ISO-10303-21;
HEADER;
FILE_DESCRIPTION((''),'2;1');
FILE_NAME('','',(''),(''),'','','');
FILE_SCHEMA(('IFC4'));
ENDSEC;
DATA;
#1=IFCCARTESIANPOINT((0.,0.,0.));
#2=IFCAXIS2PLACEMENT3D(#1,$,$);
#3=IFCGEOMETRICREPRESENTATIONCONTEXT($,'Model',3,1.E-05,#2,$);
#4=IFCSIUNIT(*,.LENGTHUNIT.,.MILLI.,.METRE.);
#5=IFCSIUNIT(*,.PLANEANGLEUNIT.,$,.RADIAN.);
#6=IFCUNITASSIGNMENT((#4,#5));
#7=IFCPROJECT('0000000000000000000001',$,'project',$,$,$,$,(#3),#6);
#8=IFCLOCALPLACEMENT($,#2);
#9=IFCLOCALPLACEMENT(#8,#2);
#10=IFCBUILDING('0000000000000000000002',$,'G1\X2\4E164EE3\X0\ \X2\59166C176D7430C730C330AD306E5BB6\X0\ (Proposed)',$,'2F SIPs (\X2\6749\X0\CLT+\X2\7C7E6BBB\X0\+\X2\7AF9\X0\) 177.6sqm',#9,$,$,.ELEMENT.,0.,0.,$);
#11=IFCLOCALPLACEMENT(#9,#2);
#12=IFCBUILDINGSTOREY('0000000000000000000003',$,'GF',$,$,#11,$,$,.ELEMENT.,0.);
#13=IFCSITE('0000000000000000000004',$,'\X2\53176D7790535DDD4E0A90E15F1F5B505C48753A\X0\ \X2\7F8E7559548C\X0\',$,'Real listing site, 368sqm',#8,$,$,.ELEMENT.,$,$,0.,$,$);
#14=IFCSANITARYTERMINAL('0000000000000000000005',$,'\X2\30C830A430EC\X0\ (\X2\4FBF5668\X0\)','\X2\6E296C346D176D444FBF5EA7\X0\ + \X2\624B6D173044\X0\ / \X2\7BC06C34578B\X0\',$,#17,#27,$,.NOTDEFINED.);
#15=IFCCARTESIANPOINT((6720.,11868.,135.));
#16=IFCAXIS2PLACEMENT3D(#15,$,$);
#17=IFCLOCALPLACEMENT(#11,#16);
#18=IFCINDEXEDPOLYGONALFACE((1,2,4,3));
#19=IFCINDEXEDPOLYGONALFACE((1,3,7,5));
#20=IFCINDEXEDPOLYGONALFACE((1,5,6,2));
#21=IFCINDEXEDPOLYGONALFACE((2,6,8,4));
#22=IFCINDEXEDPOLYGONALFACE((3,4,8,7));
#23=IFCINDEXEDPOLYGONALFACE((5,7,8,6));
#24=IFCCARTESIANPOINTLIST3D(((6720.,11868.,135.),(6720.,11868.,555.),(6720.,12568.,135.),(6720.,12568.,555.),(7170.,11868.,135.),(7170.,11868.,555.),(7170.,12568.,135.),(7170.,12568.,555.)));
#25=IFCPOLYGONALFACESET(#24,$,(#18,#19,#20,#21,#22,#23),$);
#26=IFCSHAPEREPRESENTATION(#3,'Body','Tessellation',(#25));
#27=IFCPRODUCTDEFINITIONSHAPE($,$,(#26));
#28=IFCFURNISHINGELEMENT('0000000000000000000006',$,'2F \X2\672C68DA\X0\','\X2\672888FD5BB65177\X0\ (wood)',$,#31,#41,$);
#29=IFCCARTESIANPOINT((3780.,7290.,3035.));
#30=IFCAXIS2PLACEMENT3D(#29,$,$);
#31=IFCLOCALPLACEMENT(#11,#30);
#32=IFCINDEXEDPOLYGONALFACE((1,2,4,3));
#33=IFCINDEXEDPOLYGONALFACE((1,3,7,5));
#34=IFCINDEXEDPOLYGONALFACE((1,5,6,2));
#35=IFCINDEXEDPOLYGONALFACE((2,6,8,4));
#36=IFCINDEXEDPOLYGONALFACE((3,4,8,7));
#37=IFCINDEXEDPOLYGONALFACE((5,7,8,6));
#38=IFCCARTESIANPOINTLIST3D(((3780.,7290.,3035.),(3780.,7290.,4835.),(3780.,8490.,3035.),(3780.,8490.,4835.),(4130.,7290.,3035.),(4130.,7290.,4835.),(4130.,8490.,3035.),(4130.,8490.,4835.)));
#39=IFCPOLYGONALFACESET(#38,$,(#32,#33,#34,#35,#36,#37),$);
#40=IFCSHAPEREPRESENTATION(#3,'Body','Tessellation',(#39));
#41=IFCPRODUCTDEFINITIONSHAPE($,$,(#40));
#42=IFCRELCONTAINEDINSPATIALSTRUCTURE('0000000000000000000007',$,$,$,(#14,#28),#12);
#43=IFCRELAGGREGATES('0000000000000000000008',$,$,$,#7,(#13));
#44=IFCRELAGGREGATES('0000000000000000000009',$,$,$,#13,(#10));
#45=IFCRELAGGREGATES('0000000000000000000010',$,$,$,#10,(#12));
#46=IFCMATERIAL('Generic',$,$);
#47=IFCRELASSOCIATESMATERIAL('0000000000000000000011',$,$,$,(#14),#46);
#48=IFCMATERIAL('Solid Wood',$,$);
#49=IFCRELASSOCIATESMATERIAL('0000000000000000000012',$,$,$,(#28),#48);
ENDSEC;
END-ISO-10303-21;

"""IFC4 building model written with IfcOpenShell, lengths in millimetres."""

from ifc_helpers import new_model, si_unit, frame, frame_2d, origin, place, context, project, spatial, rectangle, extrude, material, element, save


model = new_model("IFC4")

# Units and contexts
model_context = context("Model", 3, precision=1e-05, world=origin())
ifc_project = project(units=[si_unit("LENGTHUNIT", "METRE", prefix="MILLI"), si_unit("PLANEANGLEUNIT", "RADIAN")], contexts=[model_context])

# Site, building, storey
site_placement = place(None, origin())
site = spatial("IfcSite", under=ifc_project, at=site_placement, Name="北海道川上郡弟子屈町 美留和", ObjectType="Real listing site, 368sqm", CompositionType="ELEMENT", RefElevation=0.0)
building_placement = place(site_placement, origin())
building = spatial("IfcBuilding", under=site, at=building_placement, Name="G1世代 外気浴デッキの家 (Proposed)", ObjectType="2F SIPs (杉CLT+籾殻+竹) 177.6sqm", CompositionType="ELEMENT", ElevationOfRefHeight=0.0, ElevationOfTerrain=0.0)
storey_placement = place(building_placement, origin())
storey = spatial("IfcBuildingStorey", under=building, at=storey_placement, Name="GF", CompositionType="ELEMENT", Elevation=0.0)

# Shared definitions
ifc_material_1 = material(Name="Solid Wood")
ifc_material_2 = material(Name="Generic")

# Sanitary terminal
sanitary_terminal_1_placement = place(storey_placement, frame((6720.0, 11868.0, 135.0)))
element("IfcSanitaryTerminal", 1, at=sanitary_terminal_1_placement, inside=storey, material=ifc_material_2, Name="トイレ (便器)", Description="温水洗浄便座 + 手洗い / 節水型", PredefinedType="NOTDEFINED", context=model_context, shape_type="SweptSolid", body=[
    extrude(rectangle(XDim=450.0, YDim=700.0, at=frame_2d((225.0, 350.0))), frame((6720.0, 11868.0, 135.0)), (0.0, 0.0, 1.0), 420.0),
])

# Furnishing element
furnishing_placement = place(storey_placement, frame((3780.0, 7290.0, 3035.0)))
element("IfcFurnishingElement", 2, at=furnishing_placement, inside=storey, material=ifc_material_1, Name="2F 本棚", Description="木製家具 (wood)", context=model_context, shape_type="SweptSolid", body=[
    extrude(rectangle(XDim=350.0, YDim=1200.0, at=frame_2d((175.0, 600.0))), frame((3780.0, 7290.0, 3035.0)), (0.0, 0.0, 1.0), 1800.0),
])

save(model, "model.ifc")
